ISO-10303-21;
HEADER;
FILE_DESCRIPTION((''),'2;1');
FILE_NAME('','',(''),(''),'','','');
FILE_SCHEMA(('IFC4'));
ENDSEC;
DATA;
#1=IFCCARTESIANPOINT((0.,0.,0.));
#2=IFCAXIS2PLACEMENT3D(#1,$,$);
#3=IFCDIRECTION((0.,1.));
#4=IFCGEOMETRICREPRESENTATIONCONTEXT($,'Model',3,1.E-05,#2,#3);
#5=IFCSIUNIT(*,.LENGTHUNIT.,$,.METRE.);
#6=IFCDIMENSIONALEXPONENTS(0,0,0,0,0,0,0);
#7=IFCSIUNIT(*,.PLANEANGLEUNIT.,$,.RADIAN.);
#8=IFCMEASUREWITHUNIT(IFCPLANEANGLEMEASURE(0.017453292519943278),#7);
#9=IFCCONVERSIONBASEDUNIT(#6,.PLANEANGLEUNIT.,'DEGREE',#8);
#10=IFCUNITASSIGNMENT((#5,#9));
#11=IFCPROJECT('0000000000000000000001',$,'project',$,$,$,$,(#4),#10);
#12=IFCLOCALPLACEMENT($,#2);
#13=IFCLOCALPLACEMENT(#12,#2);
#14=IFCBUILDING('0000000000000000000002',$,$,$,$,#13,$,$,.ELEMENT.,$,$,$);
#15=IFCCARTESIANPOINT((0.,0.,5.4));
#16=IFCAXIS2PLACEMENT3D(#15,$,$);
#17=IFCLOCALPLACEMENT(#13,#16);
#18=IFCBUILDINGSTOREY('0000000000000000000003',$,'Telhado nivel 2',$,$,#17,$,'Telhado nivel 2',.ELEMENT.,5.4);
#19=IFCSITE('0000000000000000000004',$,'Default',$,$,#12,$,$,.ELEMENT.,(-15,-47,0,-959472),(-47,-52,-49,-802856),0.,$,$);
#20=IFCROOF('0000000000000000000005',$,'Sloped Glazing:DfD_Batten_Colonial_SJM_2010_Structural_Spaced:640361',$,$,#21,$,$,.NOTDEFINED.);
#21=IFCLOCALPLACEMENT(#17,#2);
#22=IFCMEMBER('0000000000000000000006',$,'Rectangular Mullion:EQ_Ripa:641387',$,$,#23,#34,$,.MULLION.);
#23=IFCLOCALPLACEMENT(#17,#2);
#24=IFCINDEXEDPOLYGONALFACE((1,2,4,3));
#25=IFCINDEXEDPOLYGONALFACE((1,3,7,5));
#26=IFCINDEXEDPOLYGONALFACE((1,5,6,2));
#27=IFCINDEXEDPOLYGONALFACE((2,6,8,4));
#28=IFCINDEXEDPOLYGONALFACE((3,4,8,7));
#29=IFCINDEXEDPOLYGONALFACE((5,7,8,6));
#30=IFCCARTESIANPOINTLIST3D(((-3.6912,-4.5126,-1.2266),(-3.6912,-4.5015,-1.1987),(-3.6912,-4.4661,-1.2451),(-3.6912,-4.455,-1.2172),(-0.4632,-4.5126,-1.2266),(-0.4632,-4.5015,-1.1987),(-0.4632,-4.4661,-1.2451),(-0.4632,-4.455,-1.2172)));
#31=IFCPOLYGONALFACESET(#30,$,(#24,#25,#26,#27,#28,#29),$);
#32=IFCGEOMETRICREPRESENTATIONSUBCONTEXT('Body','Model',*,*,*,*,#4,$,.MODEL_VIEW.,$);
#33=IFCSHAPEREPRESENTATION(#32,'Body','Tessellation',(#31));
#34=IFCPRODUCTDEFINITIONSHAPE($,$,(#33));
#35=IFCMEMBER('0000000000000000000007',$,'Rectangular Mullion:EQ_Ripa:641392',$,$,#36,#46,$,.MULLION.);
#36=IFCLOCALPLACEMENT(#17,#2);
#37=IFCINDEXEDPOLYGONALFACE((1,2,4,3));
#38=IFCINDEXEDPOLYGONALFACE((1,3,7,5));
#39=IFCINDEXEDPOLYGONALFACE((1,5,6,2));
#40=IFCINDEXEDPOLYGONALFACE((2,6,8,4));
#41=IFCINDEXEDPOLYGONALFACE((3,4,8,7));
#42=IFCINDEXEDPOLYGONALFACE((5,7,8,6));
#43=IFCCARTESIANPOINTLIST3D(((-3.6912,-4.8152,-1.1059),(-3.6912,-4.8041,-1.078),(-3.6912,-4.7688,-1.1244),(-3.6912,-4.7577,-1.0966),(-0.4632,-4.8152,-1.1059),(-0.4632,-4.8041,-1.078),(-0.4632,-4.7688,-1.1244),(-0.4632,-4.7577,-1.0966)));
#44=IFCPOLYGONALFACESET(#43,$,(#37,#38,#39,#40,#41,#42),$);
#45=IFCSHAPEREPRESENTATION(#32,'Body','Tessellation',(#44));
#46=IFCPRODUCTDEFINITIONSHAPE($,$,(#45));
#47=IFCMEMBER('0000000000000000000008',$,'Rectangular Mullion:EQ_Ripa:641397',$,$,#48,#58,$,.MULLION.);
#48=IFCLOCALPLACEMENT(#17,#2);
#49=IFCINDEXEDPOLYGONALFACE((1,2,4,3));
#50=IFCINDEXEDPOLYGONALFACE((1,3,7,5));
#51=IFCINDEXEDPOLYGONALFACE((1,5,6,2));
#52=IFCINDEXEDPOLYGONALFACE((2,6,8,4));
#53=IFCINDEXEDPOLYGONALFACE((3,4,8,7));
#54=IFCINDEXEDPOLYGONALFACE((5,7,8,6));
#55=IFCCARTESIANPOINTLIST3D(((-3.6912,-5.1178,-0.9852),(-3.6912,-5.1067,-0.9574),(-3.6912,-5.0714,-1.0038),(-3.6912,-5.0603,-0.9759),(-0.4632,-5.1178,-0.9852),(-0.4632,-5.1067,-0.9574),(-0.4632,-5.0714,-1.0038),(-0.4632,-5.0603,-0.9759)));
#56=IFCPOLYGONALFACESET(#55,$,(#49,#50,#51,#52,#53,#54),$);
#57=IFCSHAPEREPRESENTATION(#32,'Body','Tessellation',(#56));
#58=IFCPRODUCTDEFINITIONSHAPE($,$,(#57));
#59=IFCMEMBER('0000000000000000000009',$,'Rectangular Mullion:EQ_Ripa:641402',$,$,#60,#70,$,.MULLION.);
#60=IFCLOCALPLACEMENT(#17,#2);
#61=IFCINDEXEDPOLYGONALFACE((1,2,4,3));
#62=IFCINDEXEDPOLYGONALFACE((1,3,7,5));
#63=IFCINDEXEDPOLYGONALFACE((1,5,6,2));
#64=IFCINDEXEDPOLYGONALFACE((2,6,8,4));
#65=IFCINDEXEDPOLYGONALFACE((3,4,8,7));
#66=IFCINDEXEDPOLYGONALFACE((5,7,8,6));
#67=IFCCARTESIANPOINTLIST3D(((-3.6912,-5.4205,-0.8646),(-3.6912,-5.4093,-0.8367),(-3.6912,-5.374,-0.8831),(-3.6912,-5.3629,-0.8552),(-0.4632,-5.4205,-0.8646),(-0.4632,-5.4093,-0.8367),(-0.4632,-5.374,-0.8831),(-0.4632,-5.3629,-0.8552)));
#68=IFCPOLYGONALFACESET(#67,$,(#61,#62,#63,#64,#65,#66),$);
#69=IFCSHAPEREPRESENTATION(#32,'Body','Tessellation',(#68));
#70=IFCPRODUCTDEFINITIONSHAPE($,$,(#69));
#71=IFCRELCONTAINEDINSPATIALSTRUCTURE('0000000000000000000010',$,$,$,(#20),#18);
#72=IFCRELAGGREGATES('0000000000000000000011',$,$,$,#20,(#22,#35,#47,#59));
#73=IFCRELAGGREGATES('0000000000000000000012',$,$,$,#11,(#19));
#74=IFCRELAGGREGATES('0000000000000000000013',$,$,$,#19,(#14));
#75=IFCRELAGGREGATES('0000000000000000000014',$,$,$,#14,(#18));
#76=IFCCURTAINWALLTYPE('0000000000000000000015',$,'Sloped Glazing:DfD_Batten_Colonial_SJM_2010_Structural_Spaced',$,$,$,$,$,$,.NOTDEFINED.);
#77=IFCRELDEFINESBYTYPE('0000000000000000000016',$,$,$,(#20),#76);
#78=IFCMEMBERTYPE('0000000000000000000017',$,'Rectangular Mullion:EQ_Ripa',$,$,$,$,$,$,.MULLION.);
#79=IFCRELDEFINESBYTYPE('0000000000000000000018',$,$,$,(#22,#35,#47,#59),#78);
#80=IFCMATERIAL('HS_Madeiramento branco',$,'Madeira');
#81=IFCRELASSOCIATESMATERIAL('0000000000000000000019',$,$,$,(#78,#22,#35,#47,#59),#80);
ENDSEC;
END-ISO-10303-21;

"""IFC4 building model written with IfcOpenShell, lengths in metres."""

from ifc_helpers import new_model, entity, si_unit, converted_unit, direction, frame, origin, place, context, subcontext, project, spatial, indexed_curve, outline, extrude, source, transform, mapped, material, type_object, type_shapes, element, aggregate, save


model = new_model("IFC4")

# Units and contexts
model_context = context("Model", 3, precision=1e-05, world=origin(), true_north=direction((0.0, 1.0)))
body_context = subcontext(model_context, "Body", "Model", "MODEL_VIEW")
ifc_project = project(units=[si_unit("LENGTHUNIT", "METRE"), converted_unit("PLANEANGLEUNIT", "DEGREE", entity("IfcPlaneAngleMeasure", 0.017453292519943278), si_unit("PLANEANGLEUNIT", "RADIAN"), dimensions=[0, 0, 0, 0, 0, 0, 0])], contexts=[model_context])

# Site, building, storey
site_placement = place(None, origin())
site = spatial("IfcSite", under=ifc_project, at=site_placement, Name="Default", CompositionType="ELEMENT", RefLatitude=(-15, -47, 0, -959472), RefLongitude=(-47, -52, -49, -802856), RefElevation=0.0)
building_placement = place(site_placement, origin())
building = spatial("IfcBuilding", under=site, at=building_placement, CompositionType="ELEMENT")
storey_placement = place(building_placement, frame((0.0, 0.0, 5.4)))
storey = spatial("IfcBuildingStorey", under=building, at=storey_placement, Name="Telhado nivel 2", LongName="Telhado nivel 2", CompositionType="ELEMENT", Elevation=5.4)

# Roof, members
curtain_wall_type = type_object("IfcCurtainWallType", Name="Sloped Glazing:DfD_Batten_Colonial_SJM_2010_Structural_Spaced", PredefinedType="NOTDEFINED")
ifc_material = material(Name="HS_Madeiramento branco", Category="Madeira")
roof_1_placement = place(storey_placement, frame((0.0, 0.0, -5.4)))
roof_1 = element("IfcRoof", 1, at=roof_1_placement, inside=storey, type_object=curtain_wall_type, Name="Sloped Glazing:DfD_Batten_Colonial_SJM_2010_Structural_Spaced:640361", PredefinedType="NOTDEFINED")
member_type_1 = type_object("IfcMemberType", Name="Rectangular Mullion:EQ_Ripa", PredefinedType="MULLION", material=ifc_material)
shared_shape_1 = source(origin(), body_context, "Body", "SweptSolid", [
    extrude(outline(indexed_curve([(-0.025, -0.015), (0.025, -0.015), (0.025, 0.015), (-0.025, 0.015), (-0.025, -0.015)], self_intersect=False)), frame((0.0, 0.0, -3.228), z_axis=(0.0, 0.0, 1.0), x_axis=(-1.0, 0.0, 0.0)), (0.0, 0.0, 1.0), 3.228),
])
type_shapes(member_type_1, [shared_shape_1])
member_1_placement = place(roof_1_placement, frame((-0.4632, -4.4838, 4.1781), z_axis=(1.0, 0.0, 0.0), x_axis=(0.0, -0.928874, 0.370395)))
member_1 = element("IfcMember", 2, at=member_1_placement, type_object=member_type_1, material=ifc_material, Name="Rectangular Mullion:EQ_Ripa:641387", PredefinedType="MULLION", context=body_context, shape_type="MappedRepresentation", body=[
    mapped(shared_shape_1, transform((0.0, 0.0, 0.0), scale=1.0)),
])
member_2_placement = place(roof_1_placement, frame((-0.4632, -4.7864, 4.2988), z_axis=(1.0, 0.0, 0.0), x_axis=(0.0, -0.928874, 0.370395)))
member_2 = element("IfcMember", 3, at=member_2_placement, type_object=member_type_1, material=ifc_material, Name="Rectangular Mullion:EQ_Ripa:641392", PredefinedType="MULLION", context=body_context, shape_type="MappedRepresentation", body=[
    mapped(shared_shape_1, transform((0.0, 0.0, 0.0), scale=1.0)),
])
member_3_placement = place(roof_1_placement, frame((-0.4632, -5.0891, 4.4194), z_axis=(1.0, 0.0, 0.0), x_axis=(0.0, -0.928874, 0.370395)))
member_3 = element("IfcMember", 4, at=member_3_placement, type_object=member_type_1, material=ifc_material, Name="Rectangular Mullion:EQ_Ripa:641397", PredefinedType="MULLION", context=body_context, shape_type="MappedRepresentation", body=[
    mapped(shared_shape_1, transform((0.0, 0.0, 0.0), scale=1.0)),
])
member_4_placement = place(roof_1_placement, frame((-0.4632, -5.3917, 4.5401), z_axis=(1.0, 0.0, 0.0), x_axis=(0.0, -0.928874, 0.370395)))
member_4 = element("IfcMember", 5, at=member_4_placement, type_object=member_type_1, material=ifc_material, Name="Rectangular Mullion:EQ_Ripa:641402", PredefinedType="MULLION", context=body_context, shape_type="MappedRepresentation", body=[
    mapped(shared_shape_1, transform((0.0, 0.0, 0.0), scale=1.0)),
])
aggregate(roof_1, [member_1, member_2, member_3, member_4])

save(model, "model.ifc")
